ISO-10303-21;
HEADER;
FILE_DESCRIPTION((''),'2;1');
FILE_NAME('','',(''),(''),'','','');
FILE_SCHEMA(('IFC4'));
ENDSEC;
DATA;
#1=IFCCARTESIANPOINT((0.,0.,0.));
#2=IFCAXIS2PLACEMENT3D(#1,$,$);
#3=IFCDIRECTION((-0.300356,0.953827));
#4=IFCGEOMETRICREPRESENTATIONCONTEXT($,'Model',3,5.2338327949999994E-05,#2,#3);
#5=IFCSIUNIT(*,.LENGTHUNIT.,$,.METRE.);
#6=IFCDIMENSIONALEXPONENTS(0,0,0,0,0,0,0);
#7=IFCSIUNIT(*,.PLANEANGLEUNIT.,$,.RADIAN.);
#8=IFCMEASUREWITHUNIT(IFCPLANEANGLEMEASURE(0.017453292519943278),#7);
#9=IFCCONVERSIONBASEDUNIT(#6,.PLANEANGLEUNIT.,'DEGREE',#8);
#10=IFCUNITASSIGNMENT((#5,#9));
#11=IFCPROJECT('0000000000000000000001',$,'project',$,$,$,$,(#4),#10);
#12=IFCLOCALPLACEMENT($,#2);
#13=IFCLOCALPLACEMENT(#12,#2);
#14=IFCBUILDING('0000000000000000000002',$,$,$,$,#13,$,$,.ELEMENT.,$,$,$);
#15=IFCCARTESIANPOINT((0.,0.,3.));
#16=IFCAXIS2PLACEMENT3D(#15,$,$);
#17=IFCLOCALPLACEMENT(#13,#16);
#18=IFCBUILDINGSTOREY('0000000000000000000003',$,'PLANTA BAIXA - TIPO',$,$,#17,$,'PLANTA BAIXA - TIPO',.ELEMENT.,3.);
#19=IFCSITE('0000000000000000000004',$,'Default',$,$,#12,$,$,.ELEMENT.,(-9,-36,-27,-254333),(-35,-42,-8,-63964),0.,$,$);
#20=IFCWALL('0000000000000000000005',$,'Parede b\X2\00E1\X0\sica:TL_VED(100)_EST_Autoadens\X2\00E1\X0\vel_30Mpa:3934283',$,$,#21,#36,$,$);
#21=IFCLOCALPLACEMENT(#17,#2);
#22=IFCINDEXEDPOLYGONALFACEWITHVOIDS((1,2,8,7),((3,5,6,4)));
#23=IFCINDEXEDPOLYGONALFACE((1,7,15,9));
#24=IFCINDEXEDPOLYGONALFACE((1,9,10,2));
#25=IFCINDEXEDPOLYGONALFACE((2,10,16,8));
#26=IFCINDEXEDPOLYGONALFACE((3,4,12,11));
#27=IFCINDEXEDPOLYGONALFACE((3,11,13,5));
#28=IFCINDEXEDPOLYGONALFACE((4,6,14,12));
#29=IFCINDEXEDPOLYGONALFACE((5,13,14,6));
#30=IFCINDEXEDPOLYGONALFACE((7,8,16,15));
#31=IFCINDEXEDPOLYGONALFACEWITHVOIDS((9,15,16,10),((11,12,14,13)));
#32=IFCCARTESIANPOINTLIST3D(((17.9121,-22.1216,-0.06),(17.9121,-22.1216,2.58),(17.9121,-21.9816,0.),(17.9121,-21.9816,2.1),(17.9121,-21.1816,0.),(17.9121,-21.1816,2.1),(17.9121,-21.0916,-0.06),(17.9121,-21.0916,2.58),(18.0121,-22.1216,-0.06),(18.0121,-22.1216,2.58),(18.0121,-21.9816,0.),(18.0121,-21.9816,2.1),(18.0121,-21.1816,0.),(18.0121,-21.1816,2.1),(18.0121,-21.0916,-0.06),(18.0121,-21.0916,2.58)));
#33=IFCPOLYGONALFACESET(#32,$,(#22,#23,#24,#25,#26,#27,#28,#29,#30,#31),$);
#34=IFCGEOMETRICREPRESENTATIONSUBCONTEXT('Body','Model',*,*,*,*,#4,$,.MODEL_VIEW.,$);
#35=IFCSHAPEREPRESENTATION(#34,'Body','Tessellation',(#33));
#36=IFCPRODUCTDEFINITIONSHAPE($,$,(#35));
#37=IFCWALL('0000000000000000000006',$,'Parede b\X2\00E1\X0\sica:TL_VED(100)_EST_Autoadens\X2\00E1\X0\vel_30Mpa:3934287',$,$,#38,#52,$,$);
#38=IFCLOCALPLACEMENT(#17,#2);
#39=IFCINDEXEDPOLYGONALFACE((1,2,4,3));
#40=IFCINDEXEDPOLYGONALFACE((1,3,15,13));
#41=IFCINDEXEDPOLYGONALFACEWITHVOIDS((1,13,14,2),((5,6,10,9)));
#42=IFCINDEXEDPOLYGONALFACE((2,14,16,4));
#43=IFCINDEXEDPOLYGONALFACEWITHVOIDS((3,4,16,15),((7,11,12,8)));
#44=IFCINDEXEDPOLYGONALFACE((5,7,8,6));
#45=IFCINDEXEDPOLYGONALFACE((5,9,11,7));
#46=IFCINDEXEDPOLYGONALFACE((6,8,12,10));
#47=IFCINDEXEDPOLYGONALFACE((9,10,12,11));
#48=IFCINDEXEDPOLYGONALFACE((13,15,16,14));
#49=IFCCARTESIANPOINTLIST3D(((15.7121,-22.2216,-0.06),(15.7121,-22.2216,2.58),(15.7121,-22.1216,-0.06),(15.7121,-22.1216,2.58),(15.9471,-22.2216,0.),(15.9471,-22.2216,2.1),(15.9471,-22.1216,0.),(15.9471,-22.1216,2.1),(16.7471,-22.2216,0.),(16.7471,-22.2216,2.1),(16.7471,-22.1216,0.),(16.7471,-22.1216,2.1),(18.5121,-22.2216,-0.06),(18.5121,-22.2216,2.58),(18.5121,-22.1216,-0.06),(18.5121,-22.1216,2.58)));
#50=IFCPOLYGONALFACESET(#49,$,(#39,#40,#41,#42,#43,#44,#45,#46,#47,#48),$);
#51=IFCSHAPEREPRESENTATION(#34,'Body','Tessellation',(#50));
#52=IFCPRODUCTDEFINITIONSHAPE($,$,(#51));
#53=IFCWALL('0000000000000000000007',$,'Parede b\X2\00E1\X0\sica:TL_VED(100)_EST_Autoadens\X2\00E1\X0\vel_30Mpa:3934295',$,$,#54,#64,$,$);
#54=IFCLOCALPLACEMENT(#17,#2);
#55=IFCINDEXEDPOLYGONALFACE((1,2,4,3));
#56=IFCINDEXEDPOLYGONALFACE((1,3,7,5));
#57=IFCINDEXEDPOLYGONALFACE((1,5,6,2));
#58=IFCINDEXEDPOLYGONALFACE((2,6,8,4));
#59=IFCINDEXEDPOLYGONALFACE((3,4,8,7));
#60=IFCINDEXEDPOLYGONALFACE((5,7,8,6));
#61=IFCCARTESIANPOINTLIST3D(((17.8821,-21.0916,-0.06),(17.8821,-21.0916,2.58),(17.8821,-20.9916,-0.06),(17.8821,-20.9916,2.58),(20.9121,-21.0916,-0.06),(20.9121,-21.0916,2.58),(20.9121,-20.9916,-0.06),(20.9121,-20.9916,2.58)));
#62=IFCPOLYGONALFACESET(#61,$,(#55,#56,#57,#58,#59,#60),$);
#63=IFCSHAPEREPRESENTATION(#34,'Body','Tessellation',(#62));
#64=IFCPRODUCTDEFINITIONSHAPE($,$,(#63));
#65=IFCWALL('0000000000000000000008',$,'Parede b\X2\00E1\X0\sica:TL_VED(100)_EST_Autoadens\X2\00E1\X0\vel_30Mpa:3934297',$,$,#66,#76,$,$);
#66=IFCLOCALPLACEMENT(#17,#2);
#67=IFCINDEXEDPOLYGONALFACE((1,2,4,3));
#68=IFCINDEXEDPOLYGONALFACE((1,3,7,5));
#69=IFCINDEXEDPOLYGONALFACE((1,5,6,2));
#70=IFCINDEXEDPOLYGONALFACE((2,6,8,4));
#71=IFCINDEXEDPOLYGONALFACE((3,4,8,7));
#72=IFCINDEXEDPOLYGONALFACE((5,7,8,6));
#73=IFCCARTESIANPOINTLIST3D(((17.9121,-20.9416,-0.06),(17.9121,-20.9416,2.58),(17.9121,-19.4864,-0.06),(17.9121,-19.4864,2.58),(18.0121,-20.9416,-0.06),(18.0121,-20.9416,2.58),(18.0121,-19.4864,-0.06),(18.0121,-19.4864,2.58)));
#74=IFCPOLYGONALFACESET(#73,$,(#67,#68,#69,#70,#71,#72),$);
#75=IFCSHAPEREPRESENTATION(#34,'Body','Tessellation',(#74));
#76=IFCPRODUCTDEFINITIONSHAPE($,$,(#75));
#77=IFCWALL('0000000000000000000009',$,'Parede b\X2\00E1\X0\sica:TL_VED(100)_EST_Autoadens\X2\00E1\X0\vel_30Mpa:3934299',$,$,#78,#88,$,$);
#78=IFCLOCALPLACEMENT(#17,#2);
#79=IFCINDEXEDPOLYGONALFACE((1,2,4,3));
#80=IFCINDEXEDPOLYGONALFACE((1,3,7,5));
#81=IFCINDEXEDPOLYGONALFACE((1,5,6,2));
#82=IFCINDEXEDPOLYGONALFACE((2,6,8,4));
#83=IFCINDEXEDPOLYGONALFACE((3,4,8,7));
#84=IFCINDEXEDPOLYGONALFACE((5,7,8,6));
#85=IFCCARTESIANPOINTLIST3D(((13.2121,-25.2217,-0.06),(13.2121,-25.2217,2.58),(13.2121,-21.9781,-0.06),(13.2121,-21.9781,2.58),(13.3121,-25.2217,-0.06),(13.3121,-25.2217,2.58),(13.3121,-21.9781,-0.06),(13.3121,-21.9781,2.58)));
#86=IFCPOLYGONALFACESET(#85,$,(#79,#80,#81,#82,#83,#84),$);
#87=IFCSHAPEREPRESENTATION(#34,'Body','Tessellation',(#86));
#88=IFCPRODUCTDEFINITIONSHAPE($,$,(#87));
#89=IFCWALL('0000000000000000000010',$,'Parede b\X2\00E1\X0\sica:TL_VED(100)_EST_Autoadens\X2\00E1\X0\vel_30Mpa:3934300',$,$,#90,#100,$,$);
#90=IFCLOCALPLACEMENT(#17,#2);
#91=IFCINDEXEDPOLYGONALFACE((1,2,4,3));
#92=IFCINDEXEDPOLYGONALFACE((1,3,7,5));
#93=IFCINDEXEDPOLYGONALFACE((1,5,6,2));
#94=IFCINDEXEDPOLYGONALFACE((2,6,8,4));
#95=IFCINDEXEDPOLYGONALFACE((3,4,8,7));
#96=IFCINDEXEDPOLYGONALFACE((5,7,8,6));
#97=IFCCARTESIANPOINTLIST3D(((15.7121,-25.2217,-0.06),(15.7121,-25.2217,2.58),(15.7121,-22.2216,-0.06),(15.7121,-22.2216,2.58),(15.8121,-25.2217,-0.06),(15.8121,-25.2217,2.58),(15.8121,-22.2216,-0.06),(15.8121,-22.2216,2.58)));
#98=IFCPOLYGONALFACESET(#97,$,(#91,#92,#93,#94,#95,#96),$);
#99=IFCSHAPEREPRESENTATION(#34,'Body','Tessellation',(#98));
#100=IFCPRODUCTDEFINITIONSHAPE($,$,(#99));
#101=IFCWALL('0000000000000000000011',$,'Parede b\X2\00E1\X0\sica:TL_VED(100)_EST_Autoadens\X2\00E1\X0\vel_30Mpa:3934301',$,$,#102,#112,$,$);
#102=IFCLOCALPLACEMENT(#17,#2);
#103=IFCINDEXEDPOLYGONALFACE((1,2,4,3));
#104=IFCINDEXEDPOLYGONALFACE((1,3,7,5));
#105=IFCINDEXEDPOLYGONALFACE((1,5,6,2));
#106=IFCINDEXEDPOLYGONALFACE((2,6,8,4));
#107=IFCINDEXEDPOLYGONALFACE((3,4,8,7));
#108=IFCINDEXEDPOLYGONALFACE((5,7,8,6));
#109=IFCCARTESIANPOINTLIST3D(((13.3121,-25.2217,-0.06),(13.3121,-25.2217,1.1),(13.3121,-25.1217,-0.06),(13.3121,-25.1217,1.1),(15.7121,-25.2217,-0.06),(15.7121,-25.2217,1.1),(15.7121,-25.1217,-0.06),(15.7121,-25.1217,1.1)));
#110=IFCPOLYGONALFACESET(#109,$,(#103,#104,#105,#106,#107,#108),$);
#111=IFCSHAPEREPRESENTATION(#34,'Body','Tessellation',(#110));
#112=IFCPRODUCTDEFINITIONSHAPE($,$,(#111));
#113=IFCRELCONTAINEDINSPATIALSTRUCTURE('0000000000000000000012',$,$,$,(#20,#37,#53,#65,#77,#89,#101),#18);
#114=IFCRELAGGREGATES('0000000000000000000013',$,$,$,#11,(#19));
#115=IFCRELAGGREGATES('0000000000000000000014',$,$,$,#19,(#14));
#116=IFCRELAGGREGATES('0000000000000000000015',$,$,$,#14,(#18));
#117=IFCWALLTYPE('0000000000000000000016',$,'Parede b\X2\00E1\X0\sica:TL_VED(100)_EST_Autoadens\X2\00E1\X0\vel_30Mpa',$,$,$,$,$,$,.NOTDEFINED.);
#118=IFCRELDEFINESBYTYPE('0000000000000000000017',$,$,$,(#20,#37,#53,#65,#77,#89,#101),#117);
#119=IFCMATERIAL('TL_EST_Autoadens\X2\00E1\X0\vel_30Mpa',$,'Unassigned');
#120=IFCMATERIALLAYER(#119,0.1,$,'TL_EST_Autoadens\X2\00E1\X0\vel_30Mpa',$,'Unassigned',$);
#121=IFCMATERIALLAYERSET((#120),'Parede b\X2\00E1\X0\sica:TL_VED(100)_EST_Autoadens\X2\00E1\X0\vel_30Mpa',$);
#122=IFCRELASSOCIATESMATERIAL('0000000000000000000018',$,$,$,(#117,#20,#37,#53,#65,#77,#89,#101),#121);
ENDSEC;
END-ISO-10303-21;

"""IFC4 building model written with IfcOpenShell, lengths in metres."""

from ifc_helpers import new_model, entity, si_unit, converted_unit, direction, frame, frame_2d, origin, place, context, subcontext, project, spatial, rectangle, extrude, material, layer, layer_set, layer_usage, type_object, element, save


model = new_model("IFC4")

# Units and contexts
model_context = context("Model", 3, precision=5.2338327949999994e-05, world=origin(), true_north=direction((-0.300356, 0.953827)))
body_context = subcontext(model_context, "Body", "Model", "MODEL_VIEW")
ifc_project = project(units=[si_unit("LENGTHUNIT", "METRE"), converted_unit("PLANEANGLEUNIT", "DEGREE", entity("IfcPlaneAngleMeasure", 0.017453292519943278), si_unit("PLANEANGLEUNIT", "RADIAN"), dimensions=[0, 0, 0, 0, 0, 0, 0])], contexts=[model_context])

# Site, building, storey
site_placement = place(None, origin())
site = spatial("IfcSite", under=ifc_project, at=site_placement, Name="Default", CompositionType="ELEMENT", RefLatitude=(-9, -36, -27, -254333), RefLongitude=(-35, -42, -8, -63964), RefElevation=0.0)
building_placement = place(site_placement, origin())
building = spatial("IfcBuilding", under=site, at=building_placement, CompositionType="ELEMENT")
storey_placement = place(building_placement, frame((0.0, 0.0, 3.0)))
storey = spatial("IfcBuildingStorey", under=building, at=storey_placement, Name="PLANTA BAIXA - TIPO", LongName="PLANTA BAIXA - TIPO", CompositionType="ELEMENT", Elevation=3.0)

# Walls, openings
ifc_material_1 = material(Name="TL_EST_Autoadensável_30Mpa", Category="Unassigned")
ifc_layer_1 = layer(ifc_material_1, 0.1, Name="TL_EST_Autoadensável_30Mpa", Category="Unassigned")
ifc_layer_set_1 = layer_set([ifc_layer_1], Name="Parede básica:TL_VED(100)_EST_Autoadensável_30Mpa")
ifc_layer_usage_1 = layer_usage(ifc_layer_set_1, "AXIS2", "POSITIVE", -0.05)
wall_type_1 = type_object("IfcWallType", Name="Parede básica:TL_VED(100)_EST_Autoadensável_30Mpa", PredefinedType="NOTDEFINED", material=ifc_layer_set_1)
wall_1_placement = place(storey_placement, frame((17.9621, -22.1216, -0.06), z_axis=(0.0, 0.0, 1.0), x_axis=(0.0, 1.0, 0.0)))
wall_1 = element("IfcWall", 1, at=wall_1_placement, inside=storey, type_object=wall_type_1, material=ifc_layer_usage_1, Name="Parede básica:TL_VED(100)_EST_Autoadensável_30Mpa:3934283", context=body_context, shape_type="SweptSolid", body=[
    extrude(rectangle(XDim=1.03, YDim=0.1, at=frame_2d((0.515, 0.0), x_axis=(-1.0, 0.0))), origin(), (0.0, 0.0, 1.0), 2.64),
])
opening_1_placement = place(wall_1_placement, frame((0.94, 0.05, 0.06)))
element("IfcOpeningElement", 2, at=opening_1_placement, cuts=wall_1, PredefinedType="OPENING", context=body_context, shape_type="SweptSolid", body=[
    extrude(rectangle(XDim=2.1, YDim=0.8, at=frame_2d((1.05, 0.4), x_axis=(1.0, 0.0))), frame((0.0, 0.0, 0.0), z_axis=(0.0, -1.0, 0.0), x_axis=(0.0, 0.0, 1.0)), (0.0, 0.0, 1.0), 0.1),
])
ifc_layer_usage_2 = layer_usage(ifc_layer_set_1, "AXIS2", "POSITIVE", -0.05)
wall_2_placement = place(storey_placement, frame((15.7121, -22.1716, -0.06)))
wall_2 = element("IfcWall", 3, at=wall_2_placement, inside=storey, type_object=wall_type_1, material=ifc_layer_usage_2, Name="Parede básica:TL_VED(100)_EST_Autoadensável_30Mpa:3934287", context=body_context, shape_type="SweptSolid", body=[
    extrude(rectangle(XDim=2.8, YDim=0.1, at=frame_2d((1.4, 0.0), x_axis=(-1.0, 0.0))), origin(), (0.0, 0.0, 1.0), 2.64),
])
opening_2_placement = place(wall_2_placement, frame((1.035, 0.05, 0.06)))
element("IfcOpeningElement", 4, at=opening_2_placement, cuts=wall_2, PredefinedType="OPENING", context=body_context, shape_type="SweptSolid", body=[
    extrude(rectangle(XDim=2.1, YDim=0.8, at=frame_2d((1.05, 0.4), x_axis=(1.0, 0.0))), frame((0.0, 0.0, 0.0), z_axis=(0.0, -1.0, 0.0), x_axis=(0.0, 0.0, 1.0)), (0.0, 0.0, 1.0), 0.1),
])

# Walls
ifc_layer_usage_3 = layer_usage(ifc_layer_set_1, "AXIS2", "NEGATIVE", 0.05)
wall_3_placement = place(storey_placement, frame((17.8821, -21.0416, -0.06)))
element("IfcWall", 5, at=wall_3_placement, inside=storey, type_object=wall_type_1, material=ifc_layer_usage_3, Name="Parede básica:TL_VED(100)_EST_Autoadensável_30Mpa:3934295", context=body_context, shape_type="SweptSolid", body=[
    extrude(rectangle(XDim=3.03, YDim=0.1, at=frame_2d((1.515, 0.0), x_axis=(-1.0, 0.0))), origin(), (0.0, 0.0, 1.0), 2.64),
])
ifc_layer_usage_4 = layer_usage(ifc_layer_set_1, "AXIS2", "POSITIVE", -0.05)
wall_4_placement = place(storey_placement, frame((17.9621, -19.4864, -0.06), z_axis=(0.0, 0.0, 1.0), x_axis=(0.0, -1.0, 0.0)))
element("IfcWall", 6, at=wall_4_placement, inside=storey, type_object=wall_type_1, material=ifc_layer_usage_4, Name="Parede básica:TL_VED(100)_EST_Autoadensável_30Mpa:3934297", context=body_context, shape_type="SweptSolid", body=[
    extrude(rectangle(XDim=1.4552, YDim=0.1, at=frame_2d((0.7276, 0.0), x_axis=(-1.0, 0.0))), origin(), (0.0, 0.0, 1.0), 2.64),
])
ifc_layer_usage_5 = layer_usage(ifc_layer_set_1, "AXIS2", "NEGATIVE", 0.05)
wall_5_placement = place(storey_placement, frame((13.2621, -25.2217, -0.06), z_axis=(0.0, 0.0, 1.0), x_axis=(0.0, 1.0, 0.0)))
element("IfcWall", 7, at=wall_5_placement, inside=storey, type_object=wall_type_1, material=ifc_layer_usage_5, Name="Parede básica:TL_VED(100)_EST_Autoadensável_30Mpa:3934299", context=body_context, shape_type="SweptSolid", body=[
    extrude(rectangle(XDim=3.2437, YDim=0.1, at=frame_2d((1.6218, 0.0), x_axis=(-1.0, 0.0))), origin(), (0.0, 0.0, 1.0), 2.64),
])

# Wall, opening
ifc_layer_usage_6 = layer_usage(ifc_layer_set_1, "AXIS2", "NEGATIVE", 0.05)
wall_6_placement = place(storey_placement, frame((15.7621, -25.2217, -0.06), z_axis=(0.0, 0.0, 1.0), x_axis=(0.0, 1.0, 0.0)))
wall_6 = element("IfcWall", 8, at=wall_6_placement, inside=storey, type_object=wall_type_1, material=ifc_layer_usage_6, Name="Parede básica:TL_VED(100)_EST_Autoadensável_30Mpa:3934300", context=body_context, shape_type="SweptSolid", body=[
    extrude(rectangle(XDim=3.0001, YDim=0.1, at=frame_2d((1.5001, 0.0), x_axis=(-1.0, 0.0))), origin(), (0.0, 0.0, 1.0), 2.64),
])
opening_3_placement = place(wall_6_placement, frame((25.2217, 15.7621, 0.06)))
element("IfcOpeningElement", 9, at=opening_3_placement, cuts=wall_6, PredefinedType="OPENING", context=body_context, shape_type="SweptSolid", body=[
    extrude(rectangle(XDim=2.1, YDim=0.1, at=frame_2d((0.0, 0.0), x_axis=(0.0, 1.0))), frame((-24.2717, -15.7121, 1.05), z_axis=(0.0, 1.0, 0.0), x_axis=(1.0, 0.0, 0.0)), (0.0, 0.0, 1.0), 2.4),
])

# Wall
ifc_layer_usage_7 = layer_usage(ifc_layer_set_1, "AXIS2", "NEGATIVE", 0.05)
wall_7_placement = place(storey_placement, frame((15.7121, -25.1717, -0.06), z_axis=(0.0, 0.0, 1.0), x_axis=(-1.0, 0.0, 0.0)))
element("IfcWall", 10, at=wall_7_placement, inside=storey, type_object=wall_type_1, material=ifc_layer_usage_7, Name="Parede básica:TL_VED(100)_EST_Autoadensável_30Mpa:3934301", context=body_context, shape_type="SweptSolid", body=[
    extrude(rectangle(XDim=2.4, YDim=0.1, at=frame_2d((1.2, 0.0), x_axis=(-1.0, 0.0))), origin(), (0.0, 0.0, 1.0), 1.16),
])

save(model, "model.ifc")
